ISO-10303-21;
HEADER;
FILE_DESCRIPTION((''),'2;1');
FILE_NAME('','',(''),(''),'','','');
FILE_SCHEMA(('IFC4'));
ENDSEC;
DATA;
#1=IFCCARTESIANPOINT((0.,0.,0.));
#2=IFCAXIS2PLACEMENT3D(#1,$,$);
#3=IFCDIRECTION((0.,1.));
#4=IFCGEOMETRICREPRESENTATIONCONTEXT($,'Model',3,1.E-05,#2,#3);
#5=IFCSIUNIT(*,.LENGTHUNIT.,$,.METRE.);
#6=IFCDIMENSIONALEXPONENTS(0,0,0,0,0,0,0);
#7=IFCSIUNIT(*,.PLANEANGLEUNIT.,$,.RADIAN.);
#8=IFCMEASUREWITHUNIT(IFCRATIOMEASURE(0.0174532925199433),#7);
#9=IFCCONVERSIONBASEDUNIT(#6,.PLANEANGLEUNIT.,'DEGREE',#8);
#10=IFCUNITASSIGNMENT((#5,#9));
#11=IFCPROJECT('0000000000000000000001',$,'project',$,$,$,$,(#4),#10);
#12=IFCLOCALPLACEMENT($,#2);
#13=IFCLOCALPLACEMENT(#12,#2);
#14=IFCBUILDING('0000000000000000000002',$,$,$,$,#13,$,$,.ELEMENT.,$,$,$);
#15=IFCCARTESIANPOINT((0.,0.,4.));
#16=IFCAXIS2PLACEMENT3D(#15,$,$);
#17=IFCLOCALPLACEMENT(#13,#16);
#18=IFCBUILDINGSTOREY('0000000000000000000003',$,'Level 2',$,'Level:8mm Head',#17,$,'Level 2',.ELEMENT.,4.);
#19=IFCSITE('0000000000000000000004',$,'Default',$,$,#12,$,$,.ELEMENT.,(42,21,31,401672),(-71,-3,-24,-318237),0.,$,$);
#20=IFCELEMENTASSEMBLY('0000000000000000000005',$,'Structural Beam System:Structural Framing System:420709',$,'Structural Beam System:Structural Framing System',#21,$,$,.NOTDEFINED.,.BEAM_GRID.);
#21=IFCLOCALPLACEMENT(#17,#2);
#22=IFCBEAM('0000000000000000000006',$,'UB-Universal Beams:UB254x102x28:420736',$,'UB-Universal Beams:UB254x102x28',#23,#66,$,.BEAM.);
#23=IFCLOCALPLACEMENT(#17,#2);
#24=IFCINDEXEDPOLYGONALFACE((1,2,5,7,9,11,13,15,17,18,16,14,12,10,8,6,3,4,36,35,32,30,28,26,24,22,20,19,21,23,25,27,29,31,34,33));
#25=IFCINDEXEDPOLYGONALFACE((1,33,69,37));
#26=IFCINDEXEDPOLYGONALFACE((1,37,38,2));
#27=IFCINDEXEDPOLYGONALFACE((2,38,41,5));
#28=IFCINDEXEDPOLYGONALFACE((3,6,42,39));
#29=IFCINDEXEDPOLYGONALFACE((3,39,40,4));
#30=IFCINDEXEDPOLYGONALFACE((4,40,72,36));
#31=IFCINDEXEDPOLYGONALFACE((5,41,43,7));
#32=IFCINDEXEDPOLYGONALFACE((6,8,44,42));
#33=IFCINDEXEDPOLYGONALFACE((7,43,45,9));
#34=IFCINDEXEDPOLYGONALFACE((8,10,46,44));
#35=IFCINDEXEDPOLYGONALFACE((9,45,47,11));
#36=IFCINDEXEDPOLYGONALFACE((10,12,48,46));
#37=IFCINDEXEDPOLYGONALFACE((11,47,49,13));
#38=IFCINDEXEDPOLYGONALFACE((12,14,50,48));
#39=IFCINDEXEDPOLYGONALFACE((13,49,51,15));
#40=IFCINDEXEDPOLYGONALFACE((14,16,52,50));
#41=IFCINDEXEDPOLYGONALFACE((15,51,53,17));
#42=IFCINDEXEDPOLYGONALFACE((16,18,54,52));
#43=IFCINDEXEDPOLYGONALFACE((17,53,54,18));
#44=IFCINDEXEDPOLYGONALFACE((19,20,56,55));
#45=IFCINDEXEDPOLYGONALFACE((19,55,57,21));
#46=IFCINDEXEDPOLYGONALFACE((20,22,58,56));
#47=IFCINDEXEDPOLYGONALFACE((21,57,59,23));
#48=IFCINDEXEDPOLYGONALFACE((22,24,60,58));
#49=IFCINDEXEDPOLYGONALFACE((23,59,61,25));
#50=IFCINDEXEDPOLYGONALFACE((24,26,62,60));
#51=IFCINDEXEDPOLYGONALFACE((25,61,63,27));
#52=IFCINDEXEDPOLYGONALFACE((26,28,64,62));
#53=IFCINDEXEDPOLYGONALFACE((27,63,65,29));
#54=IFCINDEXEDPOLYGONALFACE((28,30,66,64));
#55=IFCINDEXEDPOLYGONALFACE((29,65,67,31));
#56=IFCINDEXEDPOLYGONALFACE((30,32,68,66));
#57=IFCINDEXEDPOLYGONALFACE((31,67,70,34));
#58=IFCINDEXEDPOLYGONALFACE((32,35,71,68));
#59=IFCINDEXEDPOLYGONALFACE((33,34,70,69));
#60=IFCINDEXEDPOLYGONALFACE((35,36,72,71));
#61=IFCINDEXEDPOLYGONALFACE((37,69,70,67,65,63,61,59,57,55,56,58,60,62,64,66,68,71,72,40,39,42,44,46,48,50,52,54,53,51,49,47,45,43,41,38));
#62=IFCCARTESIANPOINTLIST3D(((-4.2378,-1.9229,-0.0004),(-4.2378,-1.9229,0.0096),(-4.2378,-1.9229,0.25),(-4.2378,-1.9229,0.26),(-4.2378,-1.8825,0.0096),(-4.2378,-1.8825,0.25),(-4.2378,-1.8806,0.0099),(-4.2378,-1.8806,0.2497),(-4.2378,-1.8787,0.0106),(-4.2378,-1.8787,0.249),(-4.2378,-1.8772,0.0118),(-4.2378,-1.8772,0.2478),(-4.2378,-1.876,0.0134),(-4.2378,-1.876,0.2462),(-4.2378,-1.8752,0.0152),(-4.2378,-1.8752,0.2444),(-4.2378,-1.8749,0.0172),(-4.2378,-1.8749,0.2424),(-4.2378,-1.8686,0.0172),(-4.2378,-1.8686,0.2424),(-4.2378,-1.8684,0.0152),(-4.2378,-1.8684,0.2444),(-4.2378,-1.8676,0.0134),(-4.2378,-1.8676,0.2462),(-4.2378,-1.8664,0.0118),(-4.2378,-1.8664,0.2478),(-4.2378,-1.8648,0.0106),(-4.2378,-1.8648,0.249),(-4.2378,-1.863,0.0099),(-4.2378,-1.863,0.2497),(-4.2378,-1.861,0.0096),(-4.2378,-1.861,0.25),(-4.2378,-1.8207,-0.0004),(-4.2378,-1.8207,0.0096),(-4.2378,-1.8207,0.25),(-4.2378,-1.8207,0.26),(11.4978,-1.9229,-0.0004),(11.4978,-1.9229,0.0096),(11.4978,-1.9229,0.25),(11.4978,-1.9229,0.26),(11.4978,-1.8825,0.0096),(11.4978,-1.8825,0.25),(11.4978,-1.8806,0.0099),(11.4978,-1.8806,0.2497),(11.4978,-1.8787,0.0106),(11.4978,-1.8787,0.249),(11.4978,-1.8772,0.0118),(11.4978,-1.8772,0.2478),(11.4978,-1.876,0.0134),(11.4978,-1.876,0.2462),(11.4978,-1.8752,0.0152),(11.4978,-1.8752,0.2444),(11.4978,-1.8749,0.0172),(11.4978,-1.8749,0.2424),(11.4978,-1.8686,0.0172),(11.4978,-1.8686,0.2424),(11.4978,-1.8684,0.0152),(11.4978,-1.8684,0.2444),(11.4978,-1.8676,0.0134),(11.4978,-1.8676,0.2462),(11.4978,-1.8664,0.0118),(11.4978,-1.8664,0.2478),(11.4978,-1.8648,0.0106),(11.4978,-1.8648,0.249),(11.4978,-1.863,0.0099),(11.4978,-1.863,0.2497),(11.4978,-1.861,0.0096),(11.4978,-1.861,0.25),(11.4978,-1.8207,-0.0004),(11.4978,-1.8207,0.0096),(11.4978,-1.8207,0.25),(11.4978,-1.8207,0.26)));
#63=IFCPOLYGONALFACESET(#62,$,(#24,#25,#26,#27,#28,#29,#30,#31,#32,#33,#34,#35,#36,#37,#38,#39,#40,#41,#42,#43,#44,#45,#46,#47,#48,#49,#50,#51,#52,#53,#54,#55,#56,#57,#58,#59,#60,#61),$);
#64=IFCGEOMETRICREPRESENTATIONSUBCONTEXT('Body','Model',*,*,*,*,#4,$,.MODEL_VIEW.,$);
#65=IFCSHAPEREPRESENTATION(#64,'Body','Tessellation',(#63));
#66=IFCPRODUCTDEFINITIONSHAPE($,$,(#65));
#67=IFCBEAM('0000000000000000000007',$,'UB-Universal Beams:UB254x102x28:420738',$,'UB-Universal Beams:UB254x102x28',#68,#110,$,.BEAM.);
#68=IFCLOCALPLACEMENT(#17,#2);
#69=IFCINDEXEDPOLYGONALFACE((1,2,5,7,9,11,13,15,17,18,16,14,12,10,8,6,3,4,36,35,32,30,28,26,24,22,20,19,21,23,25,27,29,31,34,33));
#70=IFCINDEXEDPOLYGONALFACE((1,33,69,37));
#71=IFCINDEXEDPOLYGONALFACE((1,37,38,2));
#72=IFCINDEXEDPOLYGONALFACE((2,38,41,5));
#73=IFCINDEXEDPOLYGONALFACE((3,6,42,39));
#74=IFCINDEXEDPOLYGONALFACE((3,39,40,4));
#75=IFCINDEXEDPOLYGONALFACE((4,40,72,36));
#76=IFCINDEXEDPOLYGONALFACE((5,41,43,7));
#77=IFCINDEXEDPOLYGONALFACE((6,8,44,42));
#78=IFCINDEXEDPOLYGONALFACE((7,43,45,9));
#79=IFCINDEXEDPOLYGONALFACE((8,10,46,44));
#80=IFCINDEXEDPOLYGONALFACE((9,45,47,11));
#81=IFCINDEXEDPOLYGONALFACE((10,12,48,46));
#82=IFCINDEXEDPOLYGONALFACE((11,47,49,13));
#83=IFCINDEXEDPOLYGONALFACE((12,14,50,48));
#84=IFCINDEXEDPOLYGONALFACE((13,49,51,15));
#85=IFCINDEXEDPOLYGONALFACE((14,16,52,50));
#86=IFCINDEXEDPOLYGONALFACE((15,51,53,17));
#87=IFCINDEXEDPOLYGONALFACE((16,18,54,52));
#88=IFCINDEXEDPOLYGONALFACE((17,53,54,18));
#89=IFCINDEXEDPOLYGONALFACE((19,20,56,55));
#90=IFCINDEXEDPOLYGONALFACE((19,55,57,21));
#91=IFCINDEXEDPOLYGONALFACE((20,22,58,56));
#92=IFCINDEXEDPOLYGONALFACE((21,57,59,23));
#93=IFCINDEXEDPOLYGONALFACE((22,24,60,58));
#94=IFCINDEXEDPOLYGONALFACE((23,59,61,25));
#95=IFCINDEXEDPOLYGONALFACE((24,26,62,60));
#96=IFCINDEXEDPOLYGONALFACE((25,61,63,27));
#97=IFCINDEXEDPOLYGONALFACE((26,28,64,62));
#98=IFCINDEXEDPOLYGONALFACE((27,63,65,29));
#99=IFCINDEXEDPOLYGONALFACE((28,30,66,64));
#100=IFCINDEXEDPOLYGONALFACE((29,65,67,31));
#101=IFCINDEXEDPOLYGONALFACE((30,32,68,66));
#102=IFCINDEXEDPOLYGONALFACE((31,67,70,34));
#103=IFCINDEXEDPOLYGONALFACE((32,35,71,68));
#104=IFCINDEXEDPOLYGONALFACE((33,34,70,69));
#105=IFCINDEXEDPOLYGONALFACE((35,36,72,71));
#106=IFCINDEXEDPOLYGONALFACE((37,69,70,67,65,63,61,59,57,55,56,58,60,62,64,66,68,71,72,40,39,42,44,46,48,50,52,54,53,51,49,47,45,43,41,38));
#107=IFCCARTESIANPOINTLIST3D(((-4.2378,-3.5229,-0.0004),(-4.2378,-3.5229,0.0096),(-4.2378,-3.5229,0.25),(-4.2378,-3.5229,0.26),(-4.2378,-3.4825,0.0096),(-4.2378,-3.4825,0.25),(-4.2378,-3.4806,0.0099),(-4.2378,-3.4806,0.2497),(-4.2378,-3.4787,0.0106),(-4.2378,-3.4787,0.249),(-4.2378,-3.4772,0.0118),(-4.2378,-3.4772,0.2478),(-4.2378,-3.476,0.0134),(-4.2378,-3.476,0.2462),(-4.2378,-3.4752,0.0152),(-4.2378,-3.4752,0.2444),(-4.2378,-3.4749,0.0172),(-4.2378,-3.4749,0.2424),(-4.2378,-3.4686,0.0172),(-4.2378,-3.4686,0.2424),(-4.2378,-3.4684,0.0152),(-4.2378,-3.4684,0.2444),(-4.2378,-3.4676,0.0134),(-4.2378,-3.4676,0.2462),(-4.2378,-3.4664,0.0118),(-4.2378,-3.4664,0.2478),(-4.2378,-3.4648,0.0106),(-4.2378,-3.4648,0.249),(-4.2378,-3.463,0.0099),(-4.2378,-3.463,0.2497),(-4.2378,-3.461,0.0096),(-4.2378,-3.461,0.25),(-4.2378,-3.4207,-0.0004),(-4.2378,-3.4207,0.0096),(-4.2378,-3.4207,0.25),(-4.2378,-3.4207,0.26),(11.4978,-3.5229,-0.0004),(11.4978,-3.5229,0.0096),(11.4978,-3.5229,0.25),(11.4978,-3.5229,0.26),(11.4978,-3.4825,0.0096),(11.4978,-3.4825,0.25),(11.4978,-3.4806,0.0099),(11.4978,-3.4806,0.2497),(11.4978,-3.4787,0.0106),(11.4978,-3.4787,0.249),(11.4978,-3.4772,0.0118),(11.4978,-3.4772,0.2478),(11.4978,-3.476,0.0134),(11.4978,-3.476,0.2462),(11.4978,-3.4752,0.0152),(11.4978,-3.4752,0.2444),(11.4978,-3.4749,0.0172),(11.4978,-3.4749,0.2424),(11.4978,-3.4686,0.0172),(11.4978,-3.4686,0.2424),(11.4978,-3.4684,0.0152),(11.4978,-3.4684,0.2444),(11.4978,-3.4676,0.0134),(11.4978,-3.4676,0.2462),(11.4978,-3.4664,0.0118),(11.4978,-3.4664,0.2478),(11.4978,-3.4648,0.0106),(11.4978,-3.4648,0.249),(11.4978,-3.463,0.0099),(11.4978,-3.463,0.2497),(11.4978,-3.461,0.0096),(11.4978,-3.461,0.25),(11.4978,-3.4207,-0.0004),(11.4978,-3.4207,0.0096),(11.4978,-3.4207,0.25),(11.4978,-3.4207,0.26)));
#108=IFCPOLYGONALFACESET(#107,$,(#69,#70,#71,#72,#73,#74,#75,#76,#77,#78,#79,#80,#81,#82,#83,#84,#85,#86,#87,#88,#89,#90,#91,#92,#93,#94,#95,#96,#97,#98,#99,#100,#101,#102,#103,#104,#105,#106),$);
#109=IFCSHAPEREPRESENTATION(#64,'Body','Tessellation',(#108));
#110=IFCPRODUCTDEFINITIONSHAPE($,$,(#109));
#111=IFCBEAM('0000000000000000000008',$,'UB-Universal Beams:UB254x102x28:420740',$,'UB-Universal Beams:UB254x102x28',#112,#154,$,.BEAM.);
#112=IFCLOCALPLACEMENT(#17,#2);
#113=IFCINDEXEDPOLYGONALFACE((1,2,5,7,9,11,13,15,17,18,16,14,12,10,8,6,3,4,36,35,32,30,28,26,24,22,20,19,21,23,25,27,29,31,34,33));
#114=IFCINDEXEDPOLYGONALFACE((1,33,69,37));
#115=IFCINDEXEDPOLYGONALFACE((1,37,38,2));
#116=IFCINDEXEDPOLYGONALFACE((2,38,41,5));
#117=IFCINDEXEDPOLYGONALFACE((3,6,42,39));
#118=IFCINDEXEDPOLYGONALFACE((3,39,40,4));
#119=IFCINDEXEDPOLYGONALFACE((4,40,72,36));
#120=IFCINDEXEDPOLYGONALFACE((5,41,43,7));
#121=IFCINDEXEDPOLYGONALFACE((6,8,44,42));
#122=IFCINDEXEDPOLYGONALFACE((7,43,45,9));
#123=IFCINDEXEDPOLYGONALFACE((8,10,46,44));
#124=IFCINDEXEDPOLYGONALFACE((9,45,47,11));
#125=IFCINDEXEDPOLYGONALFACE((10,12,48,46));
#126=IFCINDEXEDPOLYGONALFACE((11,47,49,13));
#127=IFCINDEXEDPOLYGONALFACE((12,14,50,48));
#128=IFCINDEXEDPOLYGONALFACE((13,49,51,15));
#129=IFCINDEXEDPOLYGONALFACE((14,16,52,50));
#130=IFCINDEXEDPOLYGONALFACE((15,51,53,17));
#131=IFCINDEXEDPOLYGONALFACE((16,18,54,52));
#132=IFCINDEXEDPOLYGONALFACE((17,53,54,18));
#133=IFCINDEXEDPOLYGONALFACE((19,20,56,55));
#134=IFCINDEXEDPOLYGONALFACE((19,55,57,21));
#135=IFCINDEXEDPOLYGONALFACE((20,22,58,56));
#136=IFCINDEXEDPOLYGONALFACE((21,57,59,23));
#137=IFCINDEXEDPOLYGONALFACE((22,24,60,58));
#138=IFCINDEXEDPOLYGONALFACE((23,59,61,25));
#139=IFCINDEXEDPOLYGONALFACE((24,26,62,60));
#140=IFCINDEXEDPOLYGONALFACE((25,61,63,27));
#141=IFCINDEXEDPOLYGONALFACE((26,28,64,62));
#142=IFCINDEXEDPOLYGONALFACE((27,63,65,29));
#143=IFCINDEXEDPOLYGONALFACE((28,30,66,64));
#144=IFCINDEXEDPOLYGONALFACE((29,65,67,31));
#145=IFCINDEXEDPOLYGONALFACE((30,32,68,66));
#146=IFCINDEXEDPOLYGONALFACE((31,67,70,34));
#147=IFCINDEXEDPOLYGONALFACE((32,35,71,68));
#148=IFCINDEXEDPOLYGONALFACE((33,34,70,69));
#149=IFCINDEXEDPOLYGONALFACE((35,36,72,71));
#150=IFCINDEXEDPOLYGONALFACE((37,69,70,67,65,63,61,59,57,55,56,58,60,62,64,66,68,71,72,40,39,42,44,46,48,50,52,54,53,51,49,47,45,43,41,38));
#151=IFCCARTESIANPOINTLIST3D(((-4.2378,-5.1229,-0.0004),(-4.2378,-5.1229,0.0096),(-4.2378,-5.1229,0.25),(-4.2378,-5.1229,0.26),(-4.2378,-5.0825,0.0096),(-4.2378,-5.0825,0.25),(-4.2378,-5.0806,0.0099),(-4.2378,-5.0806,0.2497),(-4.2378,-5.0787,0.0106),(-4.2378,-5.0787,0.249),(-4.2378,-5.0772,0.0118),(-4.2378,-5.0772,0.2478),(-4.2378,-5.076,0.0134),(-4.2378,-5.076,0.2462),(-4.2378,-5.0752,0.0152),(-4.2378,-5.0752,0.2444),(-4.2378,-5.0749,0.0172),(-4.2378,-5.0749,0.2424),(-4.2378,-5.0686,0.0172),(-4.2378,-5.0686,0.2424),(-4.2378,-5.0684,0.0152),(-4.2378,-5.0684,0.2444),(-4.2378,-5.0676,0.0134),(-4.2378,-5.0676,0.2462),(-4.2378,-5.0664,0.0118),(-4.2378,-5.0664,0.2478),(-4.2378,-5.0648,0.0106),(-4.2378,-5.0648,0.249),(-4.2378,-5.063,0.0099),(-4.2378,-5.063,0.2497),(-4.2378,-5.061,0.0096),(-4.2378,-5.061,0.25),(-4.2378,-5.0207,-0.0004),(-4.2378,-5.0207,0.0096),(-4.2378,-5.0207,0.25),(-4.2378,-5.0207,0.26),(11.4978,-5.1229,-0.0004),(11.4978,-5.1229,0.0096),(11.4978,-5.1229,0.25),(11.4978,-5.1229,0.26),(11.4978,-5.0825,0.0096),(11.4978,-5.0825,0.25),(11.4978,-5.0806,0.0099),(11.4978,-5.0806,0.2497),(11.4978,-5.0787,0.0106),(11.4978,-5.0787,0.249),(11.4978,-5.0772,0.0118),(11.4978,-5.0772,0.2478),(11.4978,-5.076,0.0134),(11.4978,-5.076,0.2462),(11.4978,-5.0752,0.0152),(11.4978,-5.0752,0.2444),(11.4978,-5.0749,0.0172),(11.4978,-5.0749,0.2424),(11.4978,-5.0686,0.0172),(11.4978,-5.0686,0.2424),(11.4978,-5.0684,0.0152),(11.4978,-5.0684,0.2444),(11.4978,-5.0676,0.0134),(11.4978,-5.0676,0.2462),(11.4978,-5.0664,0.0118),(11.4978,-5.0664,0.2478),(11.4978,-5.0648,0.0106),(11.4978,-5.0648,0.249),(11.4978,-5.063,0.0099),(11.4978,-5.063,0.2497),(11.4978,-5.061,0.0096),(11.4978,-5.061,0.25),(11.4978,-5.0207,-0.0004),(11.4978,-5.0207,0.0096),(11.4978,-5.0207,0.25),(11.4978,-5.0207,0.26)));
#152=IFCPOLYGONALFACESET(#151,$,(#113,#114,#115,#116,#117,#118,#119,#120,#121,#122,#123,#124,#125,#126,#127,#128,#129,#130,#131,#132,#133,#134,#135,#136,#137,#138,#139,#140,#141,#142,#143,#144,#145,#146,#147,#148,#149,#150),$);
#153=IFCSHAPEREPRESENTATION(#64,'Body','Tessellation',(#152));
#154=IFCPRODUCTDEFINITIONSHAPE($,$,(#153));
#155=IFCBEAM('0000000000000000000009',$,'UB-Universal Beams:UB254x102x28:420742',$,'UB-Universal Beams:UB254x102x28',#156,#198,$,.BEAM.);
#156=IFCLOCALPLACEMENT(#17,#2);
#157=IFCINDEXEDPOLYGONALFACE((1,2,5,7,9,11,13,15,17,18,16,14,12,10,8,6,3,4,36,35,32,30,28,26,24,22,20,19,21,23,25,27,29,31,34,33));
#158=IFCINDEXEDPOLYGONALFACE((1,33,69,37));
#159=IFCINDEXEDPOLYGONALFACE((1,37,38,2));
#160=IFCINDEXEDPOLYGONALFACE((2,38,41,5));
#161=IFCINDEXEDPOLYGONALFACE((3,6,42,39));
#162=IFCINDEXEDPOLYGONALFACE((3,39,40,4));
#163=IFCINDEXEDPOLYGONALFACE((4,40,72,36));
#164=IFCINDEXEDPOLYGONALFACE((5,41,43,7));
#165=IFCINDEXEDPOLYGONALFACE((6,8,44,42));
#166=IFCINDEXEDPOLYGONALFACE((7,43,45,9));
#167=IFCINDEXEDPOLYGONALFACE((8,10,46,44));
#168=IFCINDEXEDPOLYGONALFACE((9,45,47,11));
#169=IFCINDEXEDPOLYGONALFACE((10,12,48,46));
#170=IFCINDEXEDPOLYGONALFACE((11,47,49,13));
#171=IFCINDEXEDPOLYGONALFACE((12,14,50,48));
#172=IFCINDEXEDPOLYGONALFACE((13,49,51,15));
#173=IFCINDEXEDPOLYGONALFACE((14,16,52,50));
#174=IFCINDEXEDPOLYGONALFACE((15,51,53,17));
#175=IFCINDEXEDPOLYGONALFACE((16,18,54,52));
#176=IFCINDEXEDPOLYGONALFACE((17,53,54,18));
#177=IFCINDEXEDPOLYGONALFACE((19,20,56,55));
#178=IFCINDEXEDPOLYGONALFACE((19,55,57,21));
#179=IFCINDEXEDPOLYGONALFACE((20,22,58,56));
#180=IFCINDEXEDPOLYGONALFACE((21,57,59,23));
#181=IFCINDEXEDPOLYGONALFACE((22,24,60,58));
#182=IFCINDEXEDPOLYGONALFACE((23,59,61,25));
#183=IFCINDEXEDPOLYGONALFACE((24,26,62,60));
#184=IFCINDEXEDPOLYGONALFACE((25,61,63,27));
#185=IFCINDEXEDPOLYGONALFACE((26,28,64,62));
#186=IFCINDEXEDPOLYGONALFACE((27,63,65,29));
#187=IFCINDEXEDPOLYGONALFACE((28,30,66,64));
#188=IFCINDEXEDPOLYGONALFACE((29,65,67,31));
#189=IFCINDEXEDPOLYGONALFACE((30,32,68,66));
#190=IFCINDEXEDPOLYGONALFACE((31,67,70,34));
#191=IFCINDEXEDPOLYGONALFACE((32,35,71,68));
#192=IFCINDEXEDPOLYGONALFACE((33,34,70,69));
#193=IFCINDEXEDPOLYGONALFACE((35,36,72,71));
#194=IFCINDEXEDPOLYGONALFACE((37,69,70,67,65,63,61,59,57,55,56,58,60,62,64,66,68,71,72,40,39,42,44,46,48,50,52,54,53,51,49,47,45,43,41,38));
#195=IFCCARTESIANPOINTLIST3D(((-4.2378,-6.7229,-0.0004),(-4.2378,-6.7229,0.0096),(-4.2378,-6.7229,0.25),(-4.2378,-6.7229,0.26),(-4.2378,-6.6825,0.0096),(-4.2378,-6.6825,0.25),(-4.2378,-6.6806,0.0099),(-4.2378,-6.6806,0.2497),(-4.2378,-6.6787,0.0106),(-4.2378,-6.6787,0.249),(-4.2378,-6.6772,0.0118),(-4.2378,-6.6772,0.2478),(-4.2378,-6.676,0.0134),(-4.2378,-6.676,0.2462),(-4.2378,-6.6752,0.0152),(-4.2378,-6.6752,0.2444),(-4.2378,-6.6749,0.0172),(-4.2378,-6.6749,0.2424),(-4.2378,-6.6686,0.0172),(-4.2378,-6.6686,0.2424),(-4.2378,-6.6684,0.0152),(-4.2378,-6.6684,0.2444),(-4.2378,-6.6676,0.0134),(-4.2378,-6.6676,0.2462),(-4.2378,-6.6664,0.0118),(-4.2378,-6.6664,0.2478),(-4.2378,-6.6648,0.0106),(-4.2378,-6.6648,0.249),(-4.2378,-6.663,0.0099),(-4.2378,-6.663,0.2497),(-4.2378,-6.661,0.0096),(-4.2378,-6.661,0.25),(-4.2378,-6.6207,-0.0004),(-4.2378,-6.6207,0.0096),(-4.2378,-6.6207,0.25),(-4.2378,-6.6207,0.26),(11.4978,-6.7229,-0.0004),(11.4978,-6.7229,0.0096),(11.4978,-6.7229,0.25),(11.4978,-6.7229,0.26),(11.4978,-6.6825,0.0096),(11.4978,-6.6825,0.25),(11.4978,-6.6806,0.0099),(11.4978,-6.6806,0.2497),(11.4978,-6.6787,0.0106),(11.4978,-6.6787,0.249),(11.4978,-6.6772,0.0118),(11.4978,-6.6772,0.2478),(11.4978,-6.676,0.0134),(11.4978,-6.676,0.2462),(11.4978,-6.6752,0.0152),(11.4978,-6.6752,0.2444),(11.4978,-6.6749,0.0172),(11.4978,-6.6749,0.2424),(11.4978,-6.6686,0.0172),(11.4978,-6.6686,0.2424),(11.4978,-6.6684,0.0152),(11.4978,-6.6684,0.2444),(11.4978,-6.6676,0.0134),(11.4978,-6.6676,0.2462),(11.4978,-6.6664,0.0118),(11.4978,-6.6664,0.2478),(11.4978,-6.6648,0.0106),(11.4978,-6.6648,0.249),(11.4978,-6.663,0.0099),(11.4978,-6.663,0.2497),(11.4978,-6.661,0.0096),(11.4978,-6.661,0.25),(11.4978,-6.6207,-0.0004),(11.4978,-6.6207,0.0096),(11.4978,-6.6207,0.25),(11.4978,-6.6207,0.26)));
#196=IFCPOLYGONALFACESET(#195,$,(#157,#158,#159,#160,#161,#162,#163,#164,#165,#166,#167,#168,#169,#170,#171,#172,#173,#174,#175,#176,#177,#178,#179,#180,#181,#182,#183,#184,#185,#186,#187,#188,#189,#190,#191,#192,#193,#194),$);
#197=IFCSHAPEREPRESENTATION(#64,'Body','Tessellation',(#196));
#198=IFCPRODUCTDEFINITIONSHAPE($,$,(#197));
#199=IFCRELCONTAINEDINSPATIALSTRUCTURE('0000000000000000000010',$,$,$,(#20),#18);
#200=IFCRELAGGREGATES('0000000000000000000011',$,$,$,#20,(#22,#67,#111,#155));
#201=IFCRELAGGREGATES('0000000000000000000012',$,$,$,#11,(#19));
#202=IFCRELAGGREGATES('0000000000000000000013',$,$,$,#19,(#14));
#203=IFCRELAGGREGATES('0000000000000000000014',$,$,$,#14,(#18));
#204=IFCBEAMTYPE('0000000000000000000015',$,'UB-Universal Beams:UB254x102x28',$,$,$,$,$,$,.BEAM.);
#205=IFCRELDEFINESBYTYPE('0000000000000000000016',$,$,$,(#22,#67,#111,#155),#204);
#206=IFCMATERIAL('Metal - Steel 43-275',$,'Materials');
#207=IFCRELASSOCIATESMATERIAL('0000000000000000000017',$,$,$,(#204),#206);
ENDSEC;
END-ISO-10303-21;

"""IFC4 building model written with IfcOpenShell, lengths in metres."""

from ifc_helpers import new_model, entity, si_unit, converted_unit, direction, frame, frame_2d, origin, place, context, subcontext, project, spatial, i_section, extrude, source, transform, mapped, material, material_profile, profile_set, type_object, type_shapes, element, aggregate, save


model = new_model("IFC4")

# Units and contexts
model_context = context("Model", 3, precision=1e-05, world=origin(), true_north=direction((0.0, 1.0)))
body_context = subcontext(model_context, "Body", "Model", "MODEL_VIEW")
ifc_project = project(units=[si_unit("LENGTHUNIT", "METRE"), converted_unit("PLANEANGLEUNIT", "DEGREE", entity("IfcRatioMeasure", 0.0174532925199433), si_unit("PLANEANGLEUNIT", "RADIAN"), dimensions=[0, 0, 0, 0, 0, 0, 0])], contexts=[model_context])

# Site, building, storey
site_placement = place(None, origin())
site = spatial("IfcSite", under=ifc_project, at=site_placement, Name="Default", CompositionType="ELEMENT", RefLatitude=(42, 21, 31, 401672), RefLongitude=(-71, -3, -24, -318237), RefElevation=0.0)
building_placement = place(site_placement, origin())
building = spatial("IfcBuilding", under=site, at=building_placement, CompositionType="ELEMENT")
storey_placement = place(building_placement, frame((0.0, 0.0, 4.0)))
storey = spatial("IfcBuildingStorey", under=building, at=storey_placement, Name="Level 2", ObjectType="Level:8mm Head", LongName="Level 2", CompositionType="ELEMENT", Elevation=4.0)

# Shared definitions
ifc_material_1 = material(Name="Metal - Steel 43-275", Category="Materials")

# Element assembly, beams
assembly_placement = place(storey_placement, origin())
assembly = element("IfcElementAssembly", 1, at=assembly_placement, inside=storey, Name="Structural Beam System:Structural Framing System:420709", ObjectType="Structural Beam System:Structural Framing System", AssemblyPlace="NOTDEFINED", PredefinedType="BEAM_GRID")
ifc_material_profile_1 = material_profile(ifc_material_1, i_section(OverallWidth=0.1022, OverallDepth=0.2604, WebThickness=0.0063, FlangeThickness=0.01, FilletRadius=0.0076, at=frame_2d((0.0, 0.0), x_axis=(0.0, 1.0))), Name="UB254x102x28")
ifc_profile_set_1 = profile_set([ifc_material_profile_1], Name="UB254x102x28")
beam_type_1 = type_object("IfcBeamType", Name="UB-Universal Beams:UB254x102x28", PredefinedType="BEAM", material=ifc_profile_set_1)
shared_shape_1 = source(origin(), body_context, "Body", "SweptSolid", [
    extrude(i_section(OverallWidth=0.1022, OverallDepth=0.2604, WebThickness=0.0063, FlangeThickness=0.01, FilletRadius=0.0076, at=frame_2d((0.0, 0.0), x_axis=(0.0, 1.0))), frame((-7.8373, 0.0, 0.0), z_axis=(1.0, 0.0, 0.0), x_axis=(0.0, 0.0, -1.0)), (0.0, 0.0, 1.0), 15.7356),
])
type_shapes(beam_type_1, [shared_shape_1])
beam_1_placement = place(assembly_placement, frame((3.5995, -1.8718, 0.1298)))
beam_1 = element("IfcBeam", 2, at=beam_1_placement, type_object=beam_type_1, Name="UB-Universal Beams:UB254x102x28:420736", ObjectType="UB-Universal Beams:UB254x102x28", PredefinedType="BEAM", context=body_context, shape_type="MappedRepresentation", body=[
    mapped(shared_shape_1, transform((0.0, 0.0, 0.0), scale=1.0)),
])
beam_2_placement = place(assembly_placement, frame((3.5995, -3.4718, 0.1298)))
beam_2 = element("IfcBeam", 3, at=beam_2_placement, type_object=beam_type_1, Name="UB-Universal Beams:UB254x102x28:420738", ObjectType="UB-Universal Beams:UB254x102x28", PredefinedType="BEAM", context=body_context, shape_type="MappedRepresentation", body=[
    mapped(shared_shape_1, transform((0.0, 0.0, 0.0), scale=1.0)),
])
beam_3_placement = place(assembly_placement, frame((3.5995, -5.0718, 0.1298)))
beam_3 = element("IfcBeam", 4, at=beam_3_placement, type_object=beam_type_1, Name="UB-Universal Beams:UB254x102x28:420740", ObjectType="UB-Universal Beams:UB254x102x28", PredefinedType="BEAM", context=body_context, shape_type="MappedRepresentation", body=[
    mapped(shared_shape_1, transform((0.0, 0.0, 0.0), scale=1.0)),
])
beam_4_placement = place(assembly_placement, frame((3.5995, -6.6718, 0.1298)))
beam_4 = element("IfcBeam", 5, at=beam_4_placement, type_object=beam_type_1, Name="UB-Universal Beams:UB254x102x28:420742", ObjectType="UB-Universal Beams:UB254x102x28", PredefinedType="BEAM", context=body_context, shape_type="MappedRepresentation", body=[
    mapped(shared_shape_1, transform((0.0, 0.0, 0.0), scale=1.0)),
])
aggregate(assembly, [beam_1, beam_2, beam_3, beam_4])

save(model, "model.ifc")
